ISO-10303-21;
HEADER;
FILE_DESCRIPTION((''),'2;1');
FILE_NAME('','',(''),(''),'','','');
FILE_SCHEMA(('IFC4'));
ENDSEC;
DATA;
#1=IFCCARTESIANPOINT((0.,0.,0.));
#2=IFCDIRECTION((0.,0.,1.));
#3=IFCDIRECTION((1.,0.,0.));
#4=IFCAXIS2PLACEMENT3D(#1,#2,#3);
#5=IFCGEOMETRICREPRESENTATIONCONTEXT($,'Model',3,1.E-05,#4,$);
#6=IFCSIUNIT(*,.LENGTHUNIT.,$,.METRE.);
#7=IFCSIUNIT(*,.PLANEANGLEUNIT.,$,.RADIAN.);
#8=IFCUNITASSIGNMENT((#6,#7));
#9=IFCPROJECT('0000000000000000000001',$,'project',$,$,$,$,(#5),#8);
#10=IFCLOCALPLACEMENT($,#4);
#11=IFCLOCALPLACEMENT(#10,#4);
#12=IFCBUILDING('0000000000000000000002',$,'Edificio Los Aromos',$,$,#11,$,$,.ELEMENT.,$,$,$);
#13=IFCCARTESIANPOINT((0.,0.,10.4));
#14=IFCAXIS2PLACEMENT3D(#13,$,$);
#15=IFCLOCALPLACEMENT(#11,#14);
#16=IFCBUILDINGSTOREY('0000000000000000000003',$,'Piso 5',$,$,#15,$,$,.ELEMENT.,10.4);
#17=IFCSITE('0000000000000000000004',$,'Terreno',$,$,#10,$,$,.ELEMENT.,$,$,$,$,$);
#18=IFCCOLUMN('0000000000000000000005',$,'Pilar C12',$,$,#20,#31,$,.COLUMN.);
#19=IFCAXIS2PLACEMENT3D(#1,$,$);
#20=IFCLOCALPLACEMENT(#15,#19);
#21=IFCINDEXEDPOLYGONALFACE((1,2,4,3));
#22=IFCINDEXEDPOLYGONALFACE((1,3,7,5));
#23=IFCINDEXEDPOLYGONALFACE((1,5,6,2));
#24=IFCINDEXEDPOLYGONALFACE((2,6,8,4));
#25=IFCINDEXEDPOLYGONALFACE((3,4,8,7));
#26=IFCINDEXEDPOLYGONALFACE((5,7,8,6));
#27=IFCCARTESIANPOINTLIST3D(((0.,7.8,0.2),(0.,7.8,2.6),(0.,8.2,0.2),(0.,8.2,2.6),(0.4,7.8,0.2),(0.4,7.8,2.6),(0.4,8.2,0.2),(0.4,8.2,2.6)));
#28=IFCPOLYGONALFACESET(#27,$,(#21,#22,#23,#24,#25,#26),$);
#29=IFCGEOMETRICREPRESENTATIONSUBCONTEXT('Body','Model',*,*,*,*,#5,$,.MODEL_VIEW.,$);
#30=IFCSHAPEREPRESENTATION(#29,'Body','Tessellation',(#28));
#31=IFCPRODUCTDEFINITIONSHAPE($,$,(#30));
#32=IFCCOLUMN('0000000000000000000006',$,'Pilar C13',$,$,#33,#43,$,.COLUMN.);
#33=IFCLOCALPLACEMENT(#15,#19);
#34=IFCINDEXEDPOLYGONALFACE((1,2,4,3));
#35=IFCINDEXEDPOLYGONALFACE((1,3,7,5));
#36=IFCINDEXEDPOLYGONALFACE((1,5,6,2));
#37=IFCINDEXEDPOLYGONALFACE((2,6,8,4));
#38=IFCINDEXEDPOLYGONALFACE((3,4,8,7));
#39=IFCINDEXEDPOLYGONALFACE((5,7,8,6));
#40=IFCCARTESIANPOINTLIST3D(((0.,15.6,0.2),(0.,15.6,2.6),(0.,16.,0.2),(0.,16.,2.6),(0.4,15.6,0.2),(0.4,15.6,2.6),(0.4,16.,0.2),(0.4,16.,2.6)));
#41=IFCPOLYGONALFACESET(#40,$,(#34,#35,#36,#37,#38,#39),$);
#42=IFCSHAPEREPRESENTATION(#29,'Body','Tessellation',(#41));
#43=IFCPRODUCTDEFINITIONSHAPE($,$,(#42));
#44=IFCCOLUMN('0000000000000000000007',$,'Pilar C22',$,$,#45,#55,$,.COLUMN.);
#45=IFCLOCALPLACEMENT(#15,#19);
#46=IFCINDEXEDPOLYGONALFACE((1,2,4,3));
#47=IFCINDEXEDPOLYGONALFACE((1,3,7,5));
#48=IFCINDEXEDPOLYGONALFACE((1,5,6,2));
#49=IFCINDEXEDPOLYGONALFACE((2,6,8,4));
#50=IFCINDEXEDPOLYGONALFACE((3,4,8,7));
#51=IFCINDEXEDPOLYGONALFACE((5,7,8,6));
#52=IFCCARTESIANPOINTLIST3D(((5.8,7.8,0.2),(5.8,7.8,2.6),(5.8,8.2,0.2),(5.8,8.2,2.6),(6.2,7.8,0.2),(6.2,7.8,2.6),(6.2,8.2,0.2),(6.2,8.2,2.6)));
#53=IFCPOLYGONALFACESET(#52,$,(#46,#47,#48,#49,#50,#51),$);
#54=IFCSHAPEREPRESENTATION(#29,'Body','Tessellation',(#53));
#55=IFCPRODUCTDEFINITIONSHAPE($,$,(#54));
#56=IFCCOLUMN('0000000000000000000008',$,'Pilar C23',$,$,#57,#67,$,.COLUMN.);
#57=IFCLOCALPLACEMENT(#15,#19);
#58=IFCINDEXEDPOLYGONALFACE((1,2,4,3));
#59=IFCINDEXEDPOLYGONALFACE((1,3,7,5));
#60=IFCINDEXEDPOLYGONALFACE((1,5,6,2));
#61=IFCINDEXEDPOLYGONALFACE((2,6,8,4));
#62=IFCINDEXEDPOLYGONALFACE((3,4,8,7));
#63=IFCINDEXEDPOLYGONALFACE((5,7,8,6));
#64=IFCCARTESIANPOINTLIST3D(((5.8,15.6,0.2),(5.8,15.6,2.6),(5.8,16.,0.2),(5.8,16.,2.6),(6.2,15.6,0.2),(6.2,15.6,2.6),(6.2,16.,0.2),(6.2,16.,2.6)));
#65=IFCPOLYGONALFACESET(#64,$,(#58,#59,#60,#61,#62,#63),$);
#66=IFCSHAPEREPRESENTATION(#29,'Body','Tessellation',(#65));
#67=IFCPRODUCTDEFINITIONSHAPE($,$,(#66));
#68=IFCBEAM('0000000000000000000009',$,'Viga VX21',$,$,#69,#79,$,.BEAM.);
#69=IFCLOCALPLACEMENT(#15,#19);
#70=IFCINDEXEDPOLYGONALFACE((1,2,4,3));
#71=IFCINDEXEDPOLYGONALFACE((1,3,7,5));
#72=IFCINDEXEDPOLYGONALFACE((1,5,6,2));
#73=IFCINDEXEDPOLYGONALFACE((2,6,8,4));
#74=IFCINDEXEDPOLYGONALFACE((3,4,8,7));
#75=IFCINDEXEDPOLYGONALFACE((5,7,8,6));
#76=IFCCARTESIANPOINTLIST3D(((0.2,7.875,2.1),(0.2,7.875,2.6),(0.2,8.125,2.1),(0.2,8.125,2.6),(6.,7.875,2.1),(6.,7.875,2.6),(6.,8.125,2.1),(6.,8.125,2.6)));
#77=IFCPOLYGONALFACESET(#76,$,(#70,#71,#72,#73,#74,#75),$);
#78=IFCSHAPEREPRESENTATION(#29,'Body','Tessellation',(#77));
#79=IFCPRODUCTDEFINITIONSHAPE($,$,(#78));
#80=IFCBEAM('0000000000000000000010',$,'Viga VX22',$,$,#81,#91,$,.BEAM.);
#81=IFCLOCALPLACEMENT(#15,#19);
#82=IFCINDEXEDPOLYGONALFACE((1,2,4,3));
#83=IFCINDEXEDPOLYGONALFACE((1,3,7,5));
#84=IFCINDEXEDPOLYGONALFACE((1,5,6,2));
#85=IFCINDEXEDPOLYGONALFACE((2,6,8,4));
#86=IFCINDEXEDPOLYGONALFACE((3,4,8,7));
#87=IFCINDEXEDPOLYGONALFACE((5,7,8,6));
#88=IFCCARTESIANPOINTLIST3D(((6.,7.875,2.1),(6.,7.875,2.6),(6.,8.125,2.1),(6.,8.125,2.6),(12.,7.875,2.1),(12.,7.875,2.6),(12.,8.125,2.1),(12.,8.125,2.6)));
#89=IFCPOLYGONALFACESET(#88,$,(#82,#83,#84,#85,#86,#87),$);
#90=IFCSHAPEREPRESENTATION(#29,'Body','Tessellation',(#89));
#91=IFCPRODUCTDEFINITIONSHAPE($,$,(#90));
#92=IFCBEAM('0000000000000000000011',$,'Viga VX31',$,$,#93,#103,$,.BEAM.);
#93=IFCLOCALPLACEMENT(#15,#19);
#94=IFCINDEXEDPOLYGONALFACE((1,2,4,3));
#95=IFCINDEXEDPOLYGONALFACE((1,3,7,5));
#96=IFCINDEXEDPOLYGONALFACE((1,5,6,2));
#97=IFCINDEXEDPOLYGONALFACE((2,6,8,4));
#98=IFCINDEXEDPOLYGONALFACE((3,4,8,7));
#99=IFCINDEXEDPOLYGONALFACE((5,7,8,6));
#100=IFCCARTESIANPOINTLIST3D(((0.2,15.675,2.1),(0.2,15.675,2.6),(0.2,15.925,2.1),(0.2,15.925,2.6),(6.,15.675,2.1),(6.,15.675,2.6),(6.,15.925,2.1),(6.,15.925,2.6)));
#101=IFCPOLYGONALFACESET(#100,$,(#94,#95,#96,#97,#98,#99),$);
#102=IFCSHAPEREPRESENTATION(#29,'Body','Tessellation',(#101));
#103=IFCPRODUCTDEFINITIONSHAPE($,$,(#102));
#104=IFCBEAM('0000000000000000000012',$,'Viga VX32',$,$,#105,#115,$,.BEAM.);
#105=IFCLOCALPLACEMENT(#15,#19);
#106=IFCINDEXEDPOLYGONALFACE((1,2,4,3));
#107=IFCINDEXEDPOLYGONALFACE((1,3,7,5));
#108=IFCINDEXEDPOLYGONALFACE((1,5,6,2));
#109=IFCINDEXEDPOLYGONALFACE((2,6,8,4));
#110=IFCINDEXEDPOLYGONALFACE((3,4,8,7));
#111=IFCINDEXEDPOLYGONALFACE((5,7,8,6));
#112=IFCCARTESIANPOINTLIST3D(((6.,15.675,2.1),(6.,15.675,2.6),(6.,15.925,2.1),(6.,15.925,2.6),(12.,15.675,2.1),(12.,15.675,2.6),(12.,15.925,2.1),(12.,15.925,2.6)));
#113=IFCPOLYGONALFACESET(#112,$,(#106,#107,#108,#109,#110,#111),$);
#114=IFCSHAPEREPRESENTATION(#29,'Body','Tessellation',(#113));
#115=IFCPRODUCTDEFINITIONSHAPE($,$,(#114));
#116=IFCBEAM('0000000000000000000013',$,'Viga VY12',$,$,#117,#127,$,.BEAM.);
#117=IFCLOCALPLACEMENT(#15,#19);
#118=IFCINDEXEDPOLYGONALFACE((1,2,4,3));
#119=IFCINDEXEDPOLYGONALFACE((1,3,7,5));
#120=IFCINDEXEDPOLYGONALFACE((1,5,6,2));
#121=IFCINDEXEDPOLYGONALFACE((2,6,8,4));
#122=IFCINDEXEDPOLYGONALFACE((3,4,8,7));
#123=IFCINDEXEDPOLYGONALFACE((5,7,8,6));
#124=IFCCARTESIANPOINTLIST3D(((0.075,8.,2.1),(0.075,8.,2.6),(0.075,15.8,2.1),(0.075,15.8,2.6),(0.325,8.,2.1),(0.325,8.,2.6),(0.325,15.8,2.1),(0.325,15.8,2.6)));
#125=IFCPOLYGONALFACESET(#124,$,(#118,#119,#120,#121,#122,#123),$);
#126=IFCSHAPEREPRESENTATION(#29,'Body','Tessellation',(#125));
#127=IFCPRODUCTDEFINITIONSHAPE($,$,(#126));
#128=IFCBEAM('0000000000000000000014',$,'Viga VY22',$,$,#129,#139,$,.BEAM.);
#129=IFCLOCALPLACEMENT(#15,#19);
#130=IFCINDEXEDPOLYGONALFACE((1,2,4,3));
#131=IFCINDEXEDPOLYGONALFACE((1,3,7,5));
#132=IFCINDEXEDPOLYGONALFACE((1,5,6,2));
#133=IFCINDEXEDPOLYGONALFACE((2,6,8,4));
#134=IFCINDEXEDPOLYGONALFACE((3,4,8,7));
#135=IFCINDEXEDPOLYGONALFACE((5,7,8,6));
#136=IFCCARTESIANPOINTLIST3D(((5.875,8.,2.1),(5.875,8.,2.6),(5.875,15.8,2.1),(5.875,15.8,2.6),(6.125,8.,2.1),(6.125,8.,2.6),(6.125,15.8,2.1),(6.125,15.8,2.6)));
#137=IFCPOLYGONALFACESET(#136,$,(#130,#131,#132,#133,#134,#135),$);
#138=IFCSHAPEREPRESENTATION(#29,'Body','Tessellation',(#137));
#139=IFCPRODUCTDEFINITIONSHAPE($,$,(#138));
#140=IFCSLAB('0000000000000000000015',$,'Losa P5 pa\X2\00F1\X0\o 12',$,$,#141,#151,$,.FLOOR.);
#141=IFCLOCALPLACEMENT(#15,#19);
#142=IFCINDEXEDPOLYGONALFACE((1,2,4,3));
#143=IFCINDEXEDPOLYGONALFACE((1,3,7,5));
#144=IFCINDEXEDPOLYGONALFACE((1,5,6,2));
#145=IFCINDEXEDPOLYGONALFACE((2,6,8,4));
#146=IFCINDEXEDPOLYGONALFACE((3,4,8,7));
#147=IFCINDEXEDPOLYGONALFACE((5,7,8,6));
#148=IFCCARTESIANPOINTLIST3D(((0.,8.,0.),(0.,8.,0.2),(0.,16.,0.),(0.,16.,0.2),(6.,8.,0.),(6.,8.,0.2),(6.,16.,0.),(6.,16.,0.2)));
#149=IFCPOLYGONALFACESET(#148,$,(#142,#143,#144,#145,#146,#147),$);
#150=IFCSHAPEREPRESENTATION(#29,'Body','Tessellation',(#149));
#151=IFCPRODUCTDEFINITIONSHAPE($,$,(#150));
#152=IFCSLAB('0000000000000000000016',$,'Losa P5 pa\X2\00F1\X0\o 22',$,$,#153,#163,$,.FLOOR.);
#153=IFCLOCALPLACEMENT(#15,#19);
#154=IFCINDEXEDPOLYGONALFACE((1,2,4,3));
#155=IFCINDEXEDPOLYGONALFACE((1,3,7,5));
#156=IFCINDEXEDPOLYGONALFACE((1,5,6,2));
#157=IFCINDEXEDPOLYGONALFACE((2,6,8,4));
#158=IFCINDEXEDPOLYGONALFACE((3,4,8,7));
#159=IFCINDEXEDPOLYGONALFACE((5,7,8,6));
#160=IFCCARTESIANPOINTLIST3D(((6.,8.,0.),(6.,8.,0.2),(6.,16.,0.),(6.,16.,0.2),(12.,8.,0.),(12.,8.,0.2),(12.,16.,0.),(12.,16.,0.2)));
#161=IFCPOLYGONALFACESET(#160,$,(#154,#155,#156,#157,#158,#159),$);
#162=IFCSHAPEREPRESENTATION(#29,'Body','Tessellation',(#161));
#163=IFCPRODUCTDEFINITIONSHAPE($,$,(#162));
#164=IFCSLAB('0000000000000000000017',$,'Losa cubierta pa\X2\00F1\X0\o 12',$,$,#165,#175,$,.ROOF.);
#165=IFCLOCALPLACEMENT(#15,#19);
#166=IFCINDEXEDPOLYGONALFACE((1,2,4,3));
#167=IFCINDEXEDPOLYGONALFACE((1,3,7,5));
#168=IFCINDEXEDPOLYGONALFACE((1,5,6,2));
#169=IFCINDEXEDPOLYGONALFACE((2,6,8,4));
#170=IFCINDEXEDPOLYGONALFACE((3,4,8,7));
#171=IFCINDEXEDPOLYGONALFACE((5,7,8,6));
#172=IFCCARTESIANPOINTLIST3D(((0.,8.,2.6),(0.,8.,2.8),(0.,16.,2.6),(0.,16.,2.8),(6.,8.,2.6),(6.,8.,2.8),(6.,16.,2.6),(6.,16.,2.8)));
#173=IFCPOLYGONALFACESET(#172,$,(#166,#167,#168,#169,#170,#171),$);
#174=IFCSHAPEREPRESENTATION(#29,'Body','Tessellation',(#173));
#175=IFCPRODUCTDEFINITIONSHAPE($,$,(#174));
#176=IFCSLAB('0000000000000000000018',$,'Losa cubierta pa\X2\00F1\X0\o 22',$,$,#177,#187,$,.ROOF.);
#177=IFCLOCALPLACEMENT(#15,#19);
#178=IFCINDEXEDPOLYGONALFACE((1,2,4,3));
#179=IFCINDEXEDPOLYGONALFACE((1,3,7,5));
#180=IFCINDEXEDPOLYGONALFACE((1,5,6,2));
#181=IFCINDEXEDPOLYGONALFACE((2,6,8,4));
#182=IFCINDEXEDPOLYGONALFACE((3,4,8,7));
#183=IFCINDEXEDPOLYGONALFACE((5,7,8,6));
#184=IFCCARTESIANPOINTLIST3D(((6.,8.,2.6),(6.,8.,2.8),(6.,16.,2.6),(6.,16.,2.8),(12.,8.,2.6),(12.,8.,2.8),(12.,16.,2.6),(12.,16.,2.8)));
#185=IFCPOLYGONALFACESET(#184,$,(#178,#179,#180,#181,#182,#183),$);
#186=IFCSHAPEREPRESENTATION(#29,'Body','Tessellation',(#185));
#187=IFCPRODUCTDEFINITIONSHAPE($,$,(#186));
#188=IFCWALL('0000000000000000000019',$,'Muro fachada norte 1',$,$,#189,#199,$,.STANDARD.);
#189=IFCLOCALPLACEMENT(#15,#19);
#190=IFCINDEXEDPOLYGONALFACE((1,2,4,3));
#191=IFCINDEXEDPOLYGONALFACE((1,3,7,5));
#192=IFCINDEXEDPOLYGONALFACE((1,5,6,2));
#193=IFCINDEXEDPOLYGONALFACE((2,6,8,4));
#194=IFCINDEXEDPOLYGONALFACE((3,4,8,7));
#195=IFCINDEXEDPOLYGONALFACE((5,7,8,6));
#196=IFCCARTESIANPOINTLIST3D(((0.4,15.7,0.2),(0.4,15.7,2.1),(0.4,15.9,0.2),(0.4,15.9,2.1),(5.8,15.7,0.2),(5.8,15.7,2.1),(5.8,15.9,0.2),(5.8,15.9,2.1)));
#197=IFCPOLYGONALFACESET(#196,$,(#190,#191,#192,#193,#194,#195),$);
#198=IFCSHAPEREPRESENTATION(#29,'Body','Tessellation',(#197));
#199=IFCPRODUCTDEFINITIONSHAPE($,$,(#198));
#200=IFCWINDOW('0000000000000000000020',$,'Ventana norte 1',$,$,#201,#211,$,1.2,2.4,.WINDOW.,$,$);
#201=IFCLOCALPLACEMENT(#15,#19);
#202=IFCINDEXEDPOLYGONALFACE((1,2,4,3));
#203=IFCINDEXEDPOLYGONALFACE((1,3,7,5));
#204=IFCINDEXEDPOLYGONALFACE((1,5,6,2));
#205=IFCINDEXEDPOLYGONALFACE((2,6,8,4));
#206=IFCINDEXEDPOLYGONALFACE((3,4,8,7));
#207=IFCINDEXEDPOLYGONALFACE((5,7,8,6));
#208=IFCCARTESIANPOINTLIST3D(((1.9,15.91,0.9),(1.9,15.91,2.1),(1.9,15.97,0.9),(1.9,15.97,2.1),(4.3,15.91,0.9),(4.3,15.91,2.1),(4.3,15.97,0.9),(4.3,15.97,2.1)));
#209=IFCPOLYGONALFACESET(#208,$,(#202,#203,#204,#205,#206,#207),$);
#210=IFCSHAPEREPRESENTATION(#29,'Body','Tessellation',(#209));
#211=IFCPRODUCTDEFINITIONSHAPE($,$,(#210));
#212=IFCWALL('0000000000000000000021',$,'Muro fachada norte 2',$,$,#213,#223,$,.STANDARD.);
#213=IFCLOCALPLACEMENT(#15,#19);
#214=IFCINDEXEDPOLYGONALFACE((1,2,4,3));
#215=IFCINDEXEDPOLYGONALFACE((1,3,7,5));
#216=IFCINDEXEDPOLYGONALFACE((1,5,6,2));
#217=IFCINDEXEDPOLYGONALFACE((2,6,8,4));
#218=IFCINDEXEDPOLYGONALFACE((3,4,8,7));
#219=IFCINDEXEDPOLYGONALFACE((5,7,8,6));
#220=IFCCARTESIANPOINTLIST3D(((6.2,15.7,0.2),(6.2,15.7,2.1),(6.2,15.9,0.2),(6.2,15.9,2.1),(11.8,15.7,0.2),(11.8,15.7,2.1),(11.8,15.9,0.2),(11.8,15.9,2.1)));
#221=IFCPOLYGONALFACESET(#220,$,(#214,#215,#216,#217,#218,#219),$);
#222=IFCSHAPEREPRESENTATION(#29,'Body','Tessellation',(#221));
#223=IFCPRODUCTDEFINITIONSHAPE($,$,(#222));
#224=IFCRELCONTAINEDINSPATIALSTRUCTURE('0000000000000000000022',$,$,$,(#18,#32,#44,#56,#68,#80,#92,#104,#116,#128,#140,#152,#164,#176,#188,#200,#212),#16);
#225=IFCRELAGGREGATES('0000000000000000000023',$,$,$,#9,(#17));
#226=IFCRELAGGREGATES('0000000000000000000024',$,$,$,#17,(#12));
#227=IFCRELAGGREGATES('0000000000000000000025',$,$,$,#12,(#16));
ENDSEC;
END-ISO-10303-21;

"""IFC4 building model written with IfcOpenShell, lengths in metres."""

from ifc_helpers import new_model, si_unit, frame, frame_2d, origin_with_axes, place, context, subcontext, project, spatial, rectangle, extrude, element, save


model = new_model("IFC4")

# Units and contexts
model_context = context("Model", 3, precision=1e-05, world=origin_with_axes())
body_context = subcontext(model_context, "Body", "Model", "MODEL_VIEW")
ifc_project = project(units=[si_unit("LENGTHUNIT", "METRE"), si_unit("PLANEANGLEUNIT", "RADIAN")], contexts=[model_context])

# Site, building, storey
site_placement = place(None, origin_with_axes())
site = spatial("IfcSite", under=ifc_project, at=site_placement, Name="Terreno", CompositionType="ELEMENT")
building_placement = place(site_placement, origin_with_axes())
building = spatial("IfcBuilding", under=site, at=building_placement, Name="Edificio Los Aromos", CompositionType="ELEMENT")
storey_placement = place(building_placement, frame((0.0, 0.0, 10.4)))
storey = spatial("IfcBuildingStorey", under=building, at=storey_placement, Name="Piso 5", CompositionType="ELEMENT", Elevation=10.4)

# Columns
for number, where, name in (
    (1, (0.0, 7.8, 0.2), "Pilar C12"),
    (2, (0.0, 15.6, 0.2), "Pilar C13"),
    (3, (5.8, 7.8, 0.2), "Pilar C22"),
    (4, (5.8, 15.6, 0.2), "Pilar C23"),
):
    element("IfcColumn", number, at=place(storey_placement, frame(where)), inside=storey, Name=name, PredefinedType="COLUMN", context=body_context, shape_type="SweptSolid", body=[
        extrude(rectangle(XDim=0.4, YDim=0.4, at=frame_2d((0.2, 0.2))), origin_with_axes(), (0.0, 0.0, 1.0), 2.4),
    ])

# Beams
beam_1_placement = place(storey_placement, frame((0.2, 7.875, 2.1)))
element("IfcBeam", 5, at=beam_1_placement, inside=storey, Name="Viga VX21", PredefinedType="BEAM", context=body_context, shape_type="SweptSolid", body=[
    extrude(rectangle(XDim=5.8, YDim=0.25, at=frame_2d((2.9, 0.125))), origin_with_axes(), (0.0, 0.0, 1.0), 0.5),
])
beam_2_placement = place(storey_placement, frame((6.0, 7.875, 2.1)))
element("IfcBeam", 6, at=beam_2_placement, inside=storey, Name="Viga VX22", PredefinedType="BEAM", context=body_context, shape_type="SweptSolid", body=[
    extrude(rectangle(XDim=6.0, YDim=0.25, at=frame_2d((3.0, 0.125))), origin_with_axes(), (0.0, 0.0, 1.0), 0.5),
])
beam_3_placement = place(storey_placement, frame((0.2, 15.675, 2.1)))
element("IfcBeam", 7, at=beam_3_placement, inside=storey, Name="Viga VX31", PredefinedType="BEAM", context=body_context, shape_type="SweptSolid", body=[
    extrude(rectangle(XDim=5.8, YDim=0.25, at=frame_2d((2.9, 0.125))), origin_with_axes(), (0.0, 0.0, 1.0), 0.5),
])
beam_4_placement = place(storey_placement, frame((6.0, 15.675, 2.1)))
element("IfcBeam", 8, at=beam_4_placement, inside=storey, Name="Viga VX32", PredefinedType="BEAM", context=body_context, shape_type="SweptSolid", body=[
    extrude(rectangle(XDim=6.0, YDim=0.25, at=frame_2d((3.0, 0.125))), origin_with_axes(), (0.0, 0.0, 1.0), 0.5),
])
for number, where, name in (
    (9, (0.075, 8.0, 2.1), "Viga VY12"),
    (10, (5.875, 8.0, 2.1), "Viga VY22"),
):
    element("IfcBeam", number, at=place(storey_placement, frame(where)), inside=storey, Name=name, PredefinedType="BEAM", context=body_context, shape_type="SweptSolid", body=[
        extrude(rectangle(XDim=0.25, YDim=7.8, at=frame_2d((0.125, 3.9))), origin_with_axes(), (0.0, 0.0, 1.0), 0.5),
    ])

# Slabs
for number, where, name in (
    (11, (0.0, 8.0, 0.0), "Losa P5 paño 12"),
    (12, (6.0, 8.0, 0.0), "Losa P5 paño 22"),
):
    element("IfcSlab", number, at=place(storey_placement, frame(where)), inside=storey, Name=name, PredefinedType="FLOOR", context=body_context, shape_type="SweptSolid", body=[
        extrude(rectangle(XDim=6.0, YDim=8.0, at=frame_2d((3.0, 4.0))), origin_with_axes(), (0.0, 0.0, 1.0), 0.2),
    ])
for number, where, name in (
    (13, (0.0, 8.0, 2.6), "Losa cubierta paño 12"),
    (14, (6.0, 8.0, 2.6), "Losa cubierta paño 22"),
):
    element("IfcSlab", number, at=place(storey_placement, frame(where)), inside=storey, Name=name, PredefinedType="ROOF", context=body_context, shape_type="SweptSolid", body=[
        extrude(rectangle(XDim=6.0, YDim=8.0, at=frame_2d((3.0, 4.0))), origin_with_axes(), (0.0, 0.0, 1.0), 0.2),
    ])

# Wall
wall_1_placement = place(storey_placement, frame((0.4, 15.7, 0.2)))
element("IfcWall", 15, at=wall_1_placement, inside=storey, Name="Muro fachada norte 1", PredefinedType="STANDARD", context=body_context, shape_type="SweptSolid", body=[
    extrude(rectangle(XDim=5.4, YDim=0.2, at=frame_2d((2.7, 0.1))), origin_with_axes(), (0.0, 0.0, 1.0), 1.9),
])

# Window
window_1_placement = place(storey_placement, frame((1.9, 15.91, 0.9)))
element("IfcWindow", 16, at=window_1_placement, inside=storey, Name="Ventana norte 1", OverallHeight=1.2, OverallWidth=2.4, PredefinedType="WINDOW", context=body_context, shape_type="SweptSolid", body=[
    extrude(rectangle(XDim=2.4, YDim=0.06, at=frame_2d((1.2, 0.03))), origin_with_axes(), (0.0, 0.0, 1.0), 1.2),
])

# Wall
wall_2_placement = place(storey_placement, frame((6.2, 15.7, 0.2)))
element("IfcWall", 17, at=wall_2_placement, inside=storey, Name="Muro fachada norte 2", PredefinedType="STANDARD", context=body_context, shape_type="SweptSolid", body=[
    extrude(rectangle(XDim=5.6, YDim=0.2, at=frame_2d((2.8, 0.1))), origin_with_axes(), (0.0, 0.0, 1.0), 1.9),
])

save(model, "model.ifc")
